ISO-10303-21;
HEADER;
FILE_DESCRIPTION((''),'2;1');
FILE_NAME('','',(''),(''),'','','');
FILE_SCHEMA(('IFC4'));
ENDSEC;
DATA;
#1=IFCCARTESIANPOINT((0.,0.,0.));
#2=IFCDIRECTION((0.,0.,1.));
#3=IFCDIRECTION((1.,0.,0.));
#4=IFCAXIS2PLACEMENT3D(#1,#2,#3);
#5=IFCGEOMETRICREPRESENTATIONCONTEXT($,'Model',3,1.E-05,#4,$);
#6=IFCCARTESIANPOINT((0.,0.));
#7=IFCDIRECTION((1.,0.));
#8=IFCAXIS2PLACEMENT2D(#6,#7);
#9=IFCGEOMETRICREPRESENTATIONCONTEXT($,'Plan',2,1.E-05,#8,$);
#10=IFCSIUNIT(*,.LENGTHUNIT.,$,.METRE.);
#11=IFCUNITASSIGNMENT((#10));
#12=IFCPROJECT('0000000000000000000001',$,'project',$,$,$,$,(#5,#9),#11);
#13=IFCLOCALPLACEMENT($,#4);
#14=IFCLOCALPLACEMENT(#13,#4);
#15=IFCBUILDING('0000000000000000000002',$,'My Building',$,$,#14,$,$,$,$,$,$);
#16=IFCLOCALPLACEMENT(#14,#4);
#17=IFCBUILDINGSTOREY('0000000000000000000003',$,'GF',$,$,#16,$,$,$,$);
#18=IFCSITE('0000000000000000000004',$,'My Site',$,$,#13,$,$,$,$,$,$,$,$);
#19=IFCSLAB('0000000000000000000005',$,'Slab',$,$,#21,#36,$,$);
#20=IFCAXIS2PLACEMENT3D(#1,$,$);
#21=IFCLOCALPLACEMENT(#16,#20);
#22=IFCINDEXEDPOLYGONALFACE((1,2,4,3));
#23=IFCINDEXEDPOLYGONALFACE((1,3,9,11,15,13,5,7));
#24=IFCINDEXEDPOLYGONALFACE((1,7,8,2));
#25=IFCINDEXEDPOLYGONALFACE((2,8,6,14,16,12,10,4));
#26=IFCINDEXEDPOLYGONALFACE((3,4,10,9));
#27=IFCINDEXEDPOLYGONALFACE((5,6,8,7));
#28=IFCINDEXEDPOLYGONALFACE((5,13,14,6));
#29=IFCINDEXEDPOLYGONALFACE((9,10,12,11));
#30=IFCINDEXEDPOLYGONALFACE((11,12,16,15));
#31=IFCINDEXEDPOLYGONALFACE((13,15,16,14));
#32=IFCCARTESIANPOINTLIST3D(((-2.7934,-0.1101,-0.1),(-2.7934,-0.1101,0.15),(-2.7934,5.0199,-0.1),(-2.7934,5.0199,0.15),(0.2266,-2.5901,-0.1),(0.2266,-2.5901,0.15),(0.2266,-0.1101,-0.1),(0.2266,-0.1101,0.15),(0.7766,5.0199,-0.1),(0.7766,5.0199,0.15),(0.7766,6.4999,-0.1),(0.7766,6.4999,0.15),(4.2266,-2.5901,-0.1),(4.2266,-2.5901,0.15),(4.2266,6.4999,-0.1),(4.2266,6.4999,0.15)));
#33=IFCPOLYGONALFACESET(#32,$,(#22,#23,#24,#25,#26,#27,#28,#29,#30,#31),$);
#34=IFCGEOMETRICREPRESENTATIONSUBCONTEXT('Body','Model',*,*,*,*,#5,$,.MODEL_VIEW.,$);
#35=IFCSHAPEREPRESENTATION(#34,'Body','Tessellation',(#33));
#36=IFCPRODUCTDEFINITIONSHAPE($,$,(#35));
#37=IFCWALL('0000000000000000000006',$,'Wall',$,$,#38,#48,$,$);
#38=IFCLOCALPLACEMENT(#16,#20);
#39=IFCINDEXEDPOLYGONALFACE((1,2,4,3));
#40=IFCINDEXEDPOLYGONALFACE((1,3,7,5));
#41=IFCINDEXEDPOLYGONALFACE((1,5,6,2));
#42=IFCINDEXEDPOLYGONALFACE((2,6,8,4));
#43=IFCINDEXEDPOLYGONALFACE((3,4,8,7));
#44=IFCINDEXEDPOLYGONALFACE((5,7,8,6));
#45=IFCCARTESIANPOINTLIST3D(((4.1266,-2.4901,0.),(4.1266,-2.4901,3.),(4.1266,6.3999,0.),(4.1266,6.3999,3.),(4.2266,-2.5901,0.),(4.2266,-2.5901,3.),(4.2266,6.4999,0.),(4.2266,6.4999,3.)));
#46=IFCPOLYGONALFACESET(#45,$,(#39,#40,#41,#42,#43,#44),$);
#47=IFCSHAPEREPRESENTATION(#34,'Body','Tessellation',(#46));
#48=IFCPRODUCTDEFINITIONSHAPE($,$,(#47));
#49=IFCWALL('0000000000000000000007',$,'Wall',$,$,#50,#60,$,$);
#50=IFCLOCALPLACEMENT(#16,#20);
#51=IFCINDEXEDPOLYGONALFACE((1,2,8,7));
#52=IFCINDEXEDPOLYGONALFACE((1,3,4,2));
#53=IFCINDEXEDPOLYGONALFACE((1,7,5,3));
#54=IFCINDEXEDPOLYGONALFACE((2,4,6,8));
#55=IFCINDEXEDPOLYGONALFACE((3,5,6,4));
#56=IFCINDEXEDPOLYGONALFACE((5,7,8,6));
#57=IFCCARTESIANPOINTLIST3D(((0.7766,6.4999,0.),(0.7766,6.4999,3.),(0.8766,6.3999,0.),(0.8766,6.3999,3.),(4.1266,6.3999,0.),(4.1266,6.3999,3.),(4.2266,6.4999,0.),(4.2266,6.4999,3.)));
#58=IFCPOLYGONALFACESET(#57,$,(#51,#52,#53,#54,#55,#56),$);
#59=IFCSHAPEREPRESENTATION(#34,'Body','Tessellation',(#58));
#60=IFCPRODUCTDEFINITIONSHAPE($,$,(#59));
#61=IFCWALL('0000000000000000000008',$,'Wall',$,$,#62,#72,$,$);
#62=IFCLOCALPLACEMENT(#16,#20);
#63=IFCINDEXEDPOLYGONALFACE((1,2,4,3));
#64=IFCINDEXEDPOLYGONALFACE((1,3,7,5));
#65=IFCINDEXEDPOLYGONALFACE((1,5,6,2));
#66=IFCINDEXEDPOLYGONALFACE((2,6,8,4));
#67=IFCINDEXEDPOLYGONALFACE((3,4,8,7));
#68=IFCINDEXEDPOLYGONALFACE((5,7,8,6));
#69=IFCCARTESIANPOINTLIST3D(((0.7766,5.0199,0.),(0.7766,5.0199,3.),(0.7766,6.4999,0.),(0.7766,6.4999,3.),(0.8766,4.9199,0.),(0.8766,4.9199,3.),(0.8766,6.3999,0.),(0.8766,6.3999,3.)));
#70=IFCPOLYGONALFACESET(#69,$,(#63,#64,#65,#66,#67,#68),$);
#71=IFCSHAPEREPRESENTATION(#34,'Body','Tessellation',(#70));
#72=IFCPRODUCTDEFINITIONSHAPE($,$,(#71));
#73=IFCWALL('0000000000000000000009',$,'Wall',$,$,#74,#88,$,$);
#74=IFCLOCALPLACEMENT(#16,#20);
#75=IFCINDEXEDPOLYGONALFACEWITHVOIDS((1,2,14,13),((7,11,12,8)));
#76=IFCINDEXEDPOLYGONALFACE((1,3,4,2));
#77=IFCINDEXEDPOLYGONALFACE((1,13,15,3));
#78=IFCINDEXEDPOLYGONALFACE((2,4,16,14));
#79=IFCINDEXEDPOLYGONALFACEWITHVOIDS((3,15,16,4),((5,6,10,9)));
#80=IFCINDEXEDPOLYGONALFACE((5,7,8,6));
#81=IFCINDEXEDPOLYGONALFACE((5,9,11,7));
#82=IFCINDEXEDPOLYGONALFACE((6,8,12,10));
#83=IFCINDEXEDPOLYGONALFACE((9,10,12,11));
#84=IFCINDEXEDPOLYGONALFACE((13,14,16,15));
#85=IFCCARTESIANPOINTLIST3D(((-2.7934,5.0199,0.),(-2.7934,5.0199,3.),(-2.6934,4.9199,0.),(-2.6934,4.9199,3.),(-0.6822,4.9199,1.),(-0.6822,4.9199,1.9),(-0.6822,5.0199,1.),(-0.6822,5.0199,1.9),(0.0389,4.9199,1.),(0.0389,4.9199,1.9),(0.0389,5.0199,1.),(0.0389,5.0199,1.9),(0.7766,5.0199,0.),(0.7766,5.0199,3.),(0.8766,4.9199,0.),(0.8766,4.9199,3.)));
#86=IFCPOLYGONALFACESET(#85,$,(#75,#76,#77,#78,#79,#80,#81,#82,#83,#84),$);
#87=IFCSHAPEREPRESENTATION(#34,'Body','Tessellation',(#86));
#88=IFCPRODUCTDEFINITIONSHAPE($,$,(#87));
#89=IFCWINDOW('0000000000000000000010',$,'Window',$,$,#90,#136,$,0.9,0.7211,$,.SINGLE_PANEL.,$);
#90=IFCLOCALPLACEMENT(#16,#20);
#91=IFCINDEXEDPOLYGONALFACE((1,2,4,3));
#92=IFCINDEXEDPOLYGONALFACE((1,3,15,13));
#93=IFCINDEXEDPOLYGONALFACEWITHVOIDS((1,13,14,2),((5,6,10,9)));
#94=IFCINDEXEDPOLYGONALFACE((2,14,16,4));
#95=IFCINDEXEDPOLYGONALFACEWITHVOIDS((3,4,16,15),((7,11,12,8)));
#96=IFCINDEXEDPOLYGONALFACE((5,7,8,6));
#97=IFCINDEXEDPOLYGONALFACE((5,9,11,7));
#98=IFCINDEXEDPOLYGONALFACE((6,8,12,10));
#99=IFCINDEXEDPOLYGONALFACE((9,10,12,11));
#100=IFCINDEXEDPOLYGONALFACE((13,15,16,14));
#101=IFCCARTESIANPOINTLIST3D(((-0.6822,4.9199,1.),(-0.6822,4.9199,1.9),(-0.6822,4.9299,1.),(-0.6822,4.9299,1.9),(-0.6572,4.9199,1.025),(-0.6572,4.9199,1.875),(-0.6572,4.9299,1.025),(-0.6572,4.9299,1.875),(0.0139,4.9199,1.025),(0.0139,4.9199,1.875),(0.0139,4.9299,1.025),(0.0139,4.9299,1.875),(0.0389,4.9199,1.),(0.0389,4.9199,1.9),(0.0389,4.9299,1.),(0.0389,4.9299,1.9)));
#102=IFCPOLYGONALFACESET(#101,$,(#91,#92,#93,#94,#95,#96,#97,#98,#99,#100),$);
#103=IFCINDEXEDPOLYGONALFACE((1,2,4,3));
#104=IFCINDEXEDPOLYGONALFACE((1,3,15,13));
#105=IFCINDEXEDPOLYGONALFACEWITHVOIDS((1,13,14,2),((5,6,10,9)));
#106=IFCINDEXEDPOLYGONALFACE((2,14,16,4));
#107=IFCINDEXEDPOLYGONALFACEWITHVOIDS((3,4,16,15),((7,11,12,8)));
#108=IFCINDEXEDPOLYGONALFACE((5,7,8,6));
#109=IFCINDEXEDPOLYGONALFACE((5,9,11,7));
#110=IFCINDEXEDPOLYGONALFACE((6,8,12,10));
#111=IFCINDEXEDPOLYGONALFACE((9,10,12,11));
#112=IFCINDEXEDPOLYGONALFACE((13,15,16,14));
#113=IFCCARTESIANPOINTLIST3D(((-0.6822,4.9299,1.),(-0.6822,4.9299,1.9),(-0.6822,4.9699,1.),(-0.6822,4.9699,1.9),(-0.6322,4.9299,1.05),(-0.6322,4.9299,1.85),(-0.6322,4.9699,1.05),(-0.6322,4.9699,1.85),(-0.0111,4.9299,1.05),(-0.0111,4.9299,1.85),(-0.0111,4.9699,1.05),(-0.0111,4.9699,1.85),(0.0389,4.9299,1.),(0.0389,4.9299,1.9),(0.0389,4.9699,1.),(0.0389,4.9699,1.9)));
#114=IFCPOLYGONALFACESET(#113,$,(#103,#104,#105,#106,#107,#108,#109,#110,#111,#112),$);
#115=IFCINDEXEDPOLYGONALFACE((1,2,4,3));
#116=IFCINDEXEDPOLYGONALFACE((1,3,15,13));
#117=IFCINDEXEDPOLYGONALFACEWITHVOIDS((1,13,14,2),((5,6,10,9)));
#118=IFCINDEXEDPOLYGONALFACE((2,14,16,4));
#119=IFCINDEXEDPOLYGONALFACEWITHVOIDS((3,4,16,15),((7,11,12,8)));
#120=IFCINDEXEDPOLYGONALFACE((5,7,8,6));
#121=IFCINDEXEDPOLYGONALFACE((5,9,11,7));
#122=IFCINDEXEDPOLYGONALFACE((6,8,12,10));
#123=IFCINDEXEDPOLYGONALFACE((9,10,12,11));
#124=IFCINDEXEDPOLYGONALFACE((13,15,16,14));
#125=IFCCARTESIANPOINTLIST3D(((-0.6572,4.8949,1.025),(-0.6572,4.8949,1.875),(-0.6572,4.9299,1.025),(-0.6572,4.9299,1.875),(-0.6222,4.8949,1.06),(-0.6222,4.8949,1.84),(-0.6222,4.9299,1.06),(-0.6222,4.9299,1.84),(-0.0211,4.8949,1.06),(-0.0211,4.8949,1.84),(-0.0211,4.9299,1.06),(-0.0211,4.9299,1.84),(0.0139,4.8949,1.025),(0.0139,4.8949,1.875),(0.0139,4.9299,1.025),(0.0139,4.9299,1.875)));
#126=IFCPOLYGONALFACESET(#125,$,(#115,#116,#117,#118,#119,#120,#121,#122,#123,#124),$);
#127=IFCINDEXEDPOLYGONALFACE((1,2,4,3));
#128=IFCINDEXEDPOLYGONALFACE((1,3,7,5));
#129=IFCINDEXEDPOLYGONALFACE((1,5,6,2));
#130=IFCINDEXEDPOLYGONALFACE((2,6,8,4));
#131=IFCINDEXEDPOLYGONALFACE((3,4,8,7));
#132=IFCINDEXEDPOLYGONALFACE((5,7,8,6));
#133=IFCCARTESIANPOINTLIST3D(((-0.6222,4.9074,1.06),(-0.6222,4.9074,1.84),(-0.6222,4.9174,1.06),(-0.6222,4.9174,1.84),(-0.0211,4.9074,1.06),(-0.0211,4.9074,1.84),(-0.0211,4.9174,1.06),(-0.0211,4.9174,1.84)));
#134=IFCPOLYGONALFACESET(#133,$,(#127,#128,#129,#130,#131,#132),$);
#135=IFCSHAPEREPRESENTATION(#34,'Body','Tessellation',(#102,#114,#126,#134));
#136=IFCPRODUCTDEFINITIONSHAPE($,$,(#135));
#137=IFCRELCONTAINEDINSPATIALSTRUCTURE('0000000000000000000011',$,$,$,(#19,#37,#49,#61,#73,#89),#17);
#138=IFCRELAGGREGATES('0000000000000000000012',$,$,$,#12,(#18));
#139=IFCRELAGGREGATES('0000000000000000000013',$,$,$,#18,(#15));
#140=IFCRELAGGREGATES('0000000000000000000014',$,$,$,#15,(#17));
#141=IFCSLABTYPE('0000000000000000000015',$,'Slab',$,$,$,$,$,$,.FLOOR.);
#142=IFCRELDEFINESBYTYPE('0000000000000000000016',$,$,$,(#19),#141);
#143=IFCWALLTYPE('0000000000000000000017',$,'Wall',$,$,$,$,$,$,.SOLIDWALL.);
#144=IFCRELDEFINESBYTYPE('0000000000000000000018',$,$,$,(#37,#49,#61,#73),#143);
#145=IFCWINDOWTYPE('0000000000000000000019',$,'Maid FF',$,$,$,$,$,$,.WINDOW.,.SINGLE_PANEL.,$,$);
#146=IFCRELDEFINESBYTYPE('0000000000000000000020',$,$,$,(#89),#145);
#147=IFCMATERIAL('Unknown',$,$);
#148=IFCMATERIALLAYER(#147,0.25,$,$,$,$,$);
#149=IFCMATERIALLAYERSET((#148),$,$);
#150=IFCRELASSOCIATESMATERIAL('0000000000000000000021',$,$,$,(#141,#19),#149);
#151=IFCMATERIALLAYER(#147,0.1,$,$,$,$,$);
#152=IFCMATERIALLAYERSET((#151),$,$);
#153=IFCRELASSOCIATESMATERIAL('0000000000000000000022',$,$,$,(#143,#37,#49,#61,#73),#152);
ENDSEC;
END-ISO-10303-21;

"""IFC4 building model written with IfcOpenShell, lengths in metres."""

from ifc_helpers import new_model, entity, si_unit, frame, origin_with_axes, origin_2d_with_axis, place, context, subcontext, project, spatial, line, indexed_curve, outline, extrude, shape, source, transform, mapped, material, layer, layer_set, layer_usage, type_object, type_shapes, element, fill, save


model = new_model("IFC4")

# Units and contexts
model_context = context("Model", 3, precision=1e-05, world=origin_with_axes())
plan_context = context("Plan", 2, precision=1e-05, world=origin_2d_with_axis())
body_context_1 = subcontext(model_context, "Body", "Model", "MODEL_VIEW")
body_context_2 = subcontext(plan_context, "Body", "Plan", "PLAN_VIEW")
ifc_project = project(units=[si_unit("LENGTHUNIT", "METRE")], contexts=[model_context, plan_context])

# Site, building, storey
site_placement = place(None, origin_with_axes())
site = spatial("IfcSite", under=ifc_project, at=site_placement, Name="My Site")
building_placement = place(site_placement, origin_with_axes())
building = spatial("IfcBuilding", under=site, at=building_placement, Name="My Building")
storey_placement = place(building_placement, origin_with_axes())
storey = spatial("IfcBuildingStorey", under=building, at=storey_placement, Name="GF")

# Slab
ifc_material_1 = material(Name="Unknown")
ifc_layer_1 = layer(ifc_material_1, 0.25)
ifc_layer_set_1 = layer_set([ifc_layer_1])
ifc_layer_usage_1 = layer_usage(ifc_layer_set_1, "AXIS3", "POSITIVE", -0.1)
slab_type_1 = type_object("IfcSlabType", Name="Slab", PredefinedType="FLOOR", material=ifc_layer_set_1)
slab_1_placement = place(storey_placement, frame((4.2266, -2.5901, 0.0), z_axis=(0.0, 0.0, 1.0), x_axis=(1.0, 0.0, 0.0)))
element("IfcSlab", 1, at=slab_1_placement, inside=storey, type_object=slab_type_1, material=ifc_layer_usage_1, Name="Slab", context=body_context_1, shape_type="SweptSolid", body=[
    extrude(outline(indexed_curve([(0.0, 0.0), (0.0, 9.09), (-3.45, 9.09), (-3.45, 7.61), (-7.02, 7.61), (-7.02, 2.48), (-4.0, 2.48), (-4.0, 0.0), (0.0, 0.0)])), frame((0.0, 0.0, -0.1), z_axis=(0.0, 0.0, 1.0), x_axis=(1.0, 0.0, 0.0)), (0.0, 0.0, 1.0), 0.25),
])

# Shared definitions
ifc_layer_2 = layer(ifc_material_1, 0.1)
ifc_layer_set_2 = layer_set([ifc_layer_2])
wall_type = type_object("IfcWallType", Name="Wall", PredefinedType="SOLIDWALL", material=ifc_layer_set_2)

# Walls
ifc_layer_usage_2 = layer_usage(ifc_layer_set_2, "AXIS2", "POSITIVE", 0.0)
wall_1_placement = place(storey_placement, frame((4.2266, -2.5901, 0.0), z_axis=(0.0, 0.0, 1.0), x_axis=(0.0, 1.0, 0.0)))
element("IfcWall", 2, at=wall_1_placement, inside=storey, type_object=wall_type, material=ifc_layer_usage_2, Name="Wall", context=body_context_1, shape_type="SweptSolid", body=[
    extrude(outline(indexed_curve([(0.0, 0.0), (0.1, 0.1), (8.99, 0.1), (9.09, 0.0)], segments=[line(1, 2, 3, 4, 1)])), origin_with_axes(), (0.0, 0.0, 1.0), 3.0),
])
ifc_layer_usage_3 = layer_usage(ifc_layer_set_2, "AXIS2", "POSITIVE", 0.0)
wall_2_placement = place(storey_placement, frame((4.2266, 6.4999, 0.0), z_axis=(0.0, 0.0, 1.0), x_axis=(-1.0, 0.0, 0.0)))
element("IfcWall", 3, at=wall_2_placement, inside=storey, type_object=wall_type, material=ifc_layer_usage_3, Name="Wall", context=body_context_1, shape_type="SweptSolid", body=[
    extrude(outline(indexed_curve([(0.0, 0.0), (0.1, 0.1), (3.35, 0.1), (3.45, 0.0)], segments=[line(1, 2, 3, 4, 1)])), origin_with_axes(), (0.0, 0.0, 1.0), 3.0),
])
ifc_layer_usage_4 = layer_usage(ifc_layer_set_2, "AXIS2", "POSITIVE", 0.0)
wall_3_placement = place(storey_placement, frame((0.7766, 6.4999, 0.0), z_axis=(0.0, 0.0, 1.0), x_axis=(0.0, -1.0, 0.0)))
element("IfcWall", 4, at=wall_3_placement, inside=storey, type_object=wall_type, material=ifc_layer_usage_4, Name="Wall", context=body_context_1, shape_type="SweptSolid", body=[
    extrude(outline(indexed_curve([(0.0, 0.0), (0.1, 0.1), (1.58, 0.1), (1.48, 0.0)], segments=[line(1, 2, 3, 4, 1)])), origin_with_axes(), (0.0, 0.0, 1.0), 3.0),
])

# Wall, opening, window
ifc_layer_usage_5 = layer_usage(ifc_layer_set_2, "AXIS2", "POSITIVE", 0.0)
wall_4_placement = place(storey_placement, frame((0.7766, 5.0199, 0.0), z_axis=(0.0, 0.0, 1.0), x_axis=(-1.0, 0.0, 0.0)))
wall_4 = element("IfcWall", 5, at=wall_4_placement, inside=storey, type_object=wall_type, material=ifc_layer_usage_5, Name="Wall", context=body_context_1, shape_type="SweptSolid", body=[
    extrude(outline(indexed_curve([(0.0, 0.0), (-0.1, 0.1), (3.47, 0.1), (3.57, 0.0)], segments=[line(1, 2, 3, 4, 1)])), origin_with_axes(), (0.0, 0.0, 1.0), 3.0),
])
shared_shape_1 = source(origin_with_axes(), body_context_1, "Body", "SweptSolid", [
    extrude(outline(indexed_curve([(0.0, 0.0), (0.7211, 0.0), (0.7211, 0.9), (0.0, 0.9)], segments=[line(1, 2, 3, 4, 1)])), frame((0.0, -0.6, 0.0), z_axis=(0.0, -1.0, 0.0), x_axis=(1.0, 0.0, 0.0)), (0.0, 0.0, -1.0), 1.2),
])
opening_1_placement = place(wall_4_placement, frame((0.7377, 0.0, 1.0), z_axis=(0.0, 0.0, 1.0), x_axis=(1.0, 0.0, 0.0)))
opening_1 = element("IfcOpeningElement", 6, at=opening_1_placement, cuts=wall_4, PredefinedType="OPENING", context=body_context_1, shape_type="MappedRepresentation", body=[
    mapped(shared_shape_1, transform((0.0, 0.0, 0.0), x_axis=(1.0, 0.0, 0.0), y_axis=(0.0, 1.0, 0.0), z_axis=(0.0, 0.0, 1.0), scale=1.0)),
])
window_type_1 = type_object("IfcWindowType", Name="Maid FF", PartitioningType="SINGLE_PANEL", PredefinedType="WINDOW")
shared_shape_2 = source(origin_with_axes(), body_context_1, "Body", "SweptSolid", [
    extrude(outline(indexed_curve([(0.0, 0.0), (0.7211, 0.0), (0.7211, 0.9), (0.0, 0.9)], segments=[line(1, 2, 3, 4, 1)]), holes=[indexed_curve([(0.025, 0.025), (0.6961, 0.025), (0.6961, 0.875), (0.025, 0.875)], segments=[line(1, 2, 3, 4, 1)])]), frame((0.0, 0.09, 0.0), z_axis=(0.0, -1.0, 0.0), x_axis=(1.0, 0.0, 0.0)), (0.0, 0.0, -1.0), 0.01),
    extrude(outline(indexed_curve([(0.0, 0.0), (0.7211, 0.0), (0.7211, 0.9), (0.0, 0.9)], segments=[line(1, 2, 3, 4, 1)]), holes=[indexed_curve([(0.05, 0.05), (0.6711, 0.05), (0.6711, 0.85), (0.05, 0.85)], segments=[line(1, 2, 3, 4, 1)])]), frame((0.0, 0.05, 0.0), z_axis=(0.0, -1.0, 0.0), x_axis=(1.0, 0.0, 0.0)), (0.0, 0.0, -1.0), 0.04),
    extrude(outline(indexed_curve([(0.0, 0.0), (0.6711, 0.0), (0.6711, 0.85), (0.0, 0.85)], segments=[line(1, 2, 3, 4, 1)]), holes=[indexed_curve([(0.035, 0.035), (0.6361, 0.035), (0.6361, 0.815), (0.035, 0.815)], segments=[line(1, 2, 3, 4, 1)])]), frame((0.025, 0.09, 0.025), z_axis=(0.0, -1.0, 0.0), x_axis=(1.0, 0.0, 0.0)), (0.0, 0.0, -1.0), 0.035),
    extrude(outline(indexed_curve([(0.035, 0.035), (0.6361, 0.035), (0.6361, 0.815), (0.035, 0.815)], segments=[line(1, 2, 3, 4, 1)])), frame((0.025, 0.1025, 0.025), z_axis=(0.0, -1.0, 0.0), x_axis=(1.0, 0.0, 0.0)), (0.0, 0.0, -1.0), 0.01),
])
shared_shape_3 = source(origin_with_axes(), body_context_2, "Body", "Curve2D", [
    entity("IfcIndexedPolyCurve", entity("IfcCartesianPointList2D", [[0.05, 0.05], [0.6711, 0.05]])),
    entity("IfcIndexedPolyCurve", entity("IfcCartesianPointList2D", [[0.0, 0.1], [0.025, 0.1], [0.025, 0.09], [0.05, 0.09], [0.05, 0.05], [0.0, 0.05]]), [entity("IfcLineIndex", [1, 2, 3, 4, 5, 6, 1])]),
    entity("IfcIndexedPolyCurve", entity("IfcCartesianPointList2D", [[0.7211, 0.1], [0.6961, 0.1], [0.6961, 0.09], [0.6711, 0.09], [0.6711, 0.05], [0.7211, 0.05]]), [entity("IfcLineIndex", [1, 2, 3, 4, 5, 6, 1])]),
    entity("IfcIndexedPolyCurve", entity("IfcCartesianPointList2D", [[0.025, 0.09], [0.06, 0.09], [0.06, 0.125], [0.025, 0.125]]), [entity("IfcLineIndex", [1, 2, 3, 4, 1])]),
    entity("IfcIndexedPolyCurve", entity("IfcCartesianPointList2D", [[0.6961, 0.09], [0.6611, 0.09], [0.6611, 0.125], [0.6961, 0.125]]), [entity("IfcLineIndex", [1, 2, 3, 4, 1])]),
    entity("IfcIndexedPolyCurve", entity("IfcCartesianPointList2D", [[0.06, 0.09], [0.6611, 0.09]])),
    entity("IfcIndexedPolyCurve", entity("IfcCartesianPointList2D", [[0.06, 0.125], [0.6611, 0.125]])),
    entity("IfcIndexedPolyCurve", entity("IfcCartesianPointList2D", [[0.06, 0.1075], [0.6611, 0.1075]])),
])
type_shapes(window_type_1, [shared_shape_2, shared_shape_3])
window_1_placement = place(opening_1_placement, frame((0.0, 0.0, 0.0), z_axis=(0.0, 0.0, 1.0), x_axis=(1.0, 0.0, 0.0)))
window_1 = element("IfcWindow", 7, at=window_1_placement, inside=storey, type_object=window_type_1, Name="Window", OverallHeight=0.9, OverallWidth=0.7211, PartitioningType="SINGLE_PANEL", shapes=[
    shape(body_context_1, "Body", "MappedRepresentation", [mapped(shared_shape_2, transform((0.0, 0.0, 0.0), x_axis=(1.0, 0.0, 0.0), y_axis=(0.0, 1.0, 0.0), z_axis=(0.0, 0.0, 1.0), scale=1.0))]),
    shape(body_context_2, "Body", "MappedRepresentation", [mapped(shared_shape_3, transform((0.0, 0.0, 0.0), x_axis=(1.0, 0.0, 0.0), y_axis=(0.0, 1.0, 0.0), z_axis=(0.0, 0.0, 1.0), scale=1.0))]),
])
fill(opening_1, window_1)

save(model, "model.ifc")
